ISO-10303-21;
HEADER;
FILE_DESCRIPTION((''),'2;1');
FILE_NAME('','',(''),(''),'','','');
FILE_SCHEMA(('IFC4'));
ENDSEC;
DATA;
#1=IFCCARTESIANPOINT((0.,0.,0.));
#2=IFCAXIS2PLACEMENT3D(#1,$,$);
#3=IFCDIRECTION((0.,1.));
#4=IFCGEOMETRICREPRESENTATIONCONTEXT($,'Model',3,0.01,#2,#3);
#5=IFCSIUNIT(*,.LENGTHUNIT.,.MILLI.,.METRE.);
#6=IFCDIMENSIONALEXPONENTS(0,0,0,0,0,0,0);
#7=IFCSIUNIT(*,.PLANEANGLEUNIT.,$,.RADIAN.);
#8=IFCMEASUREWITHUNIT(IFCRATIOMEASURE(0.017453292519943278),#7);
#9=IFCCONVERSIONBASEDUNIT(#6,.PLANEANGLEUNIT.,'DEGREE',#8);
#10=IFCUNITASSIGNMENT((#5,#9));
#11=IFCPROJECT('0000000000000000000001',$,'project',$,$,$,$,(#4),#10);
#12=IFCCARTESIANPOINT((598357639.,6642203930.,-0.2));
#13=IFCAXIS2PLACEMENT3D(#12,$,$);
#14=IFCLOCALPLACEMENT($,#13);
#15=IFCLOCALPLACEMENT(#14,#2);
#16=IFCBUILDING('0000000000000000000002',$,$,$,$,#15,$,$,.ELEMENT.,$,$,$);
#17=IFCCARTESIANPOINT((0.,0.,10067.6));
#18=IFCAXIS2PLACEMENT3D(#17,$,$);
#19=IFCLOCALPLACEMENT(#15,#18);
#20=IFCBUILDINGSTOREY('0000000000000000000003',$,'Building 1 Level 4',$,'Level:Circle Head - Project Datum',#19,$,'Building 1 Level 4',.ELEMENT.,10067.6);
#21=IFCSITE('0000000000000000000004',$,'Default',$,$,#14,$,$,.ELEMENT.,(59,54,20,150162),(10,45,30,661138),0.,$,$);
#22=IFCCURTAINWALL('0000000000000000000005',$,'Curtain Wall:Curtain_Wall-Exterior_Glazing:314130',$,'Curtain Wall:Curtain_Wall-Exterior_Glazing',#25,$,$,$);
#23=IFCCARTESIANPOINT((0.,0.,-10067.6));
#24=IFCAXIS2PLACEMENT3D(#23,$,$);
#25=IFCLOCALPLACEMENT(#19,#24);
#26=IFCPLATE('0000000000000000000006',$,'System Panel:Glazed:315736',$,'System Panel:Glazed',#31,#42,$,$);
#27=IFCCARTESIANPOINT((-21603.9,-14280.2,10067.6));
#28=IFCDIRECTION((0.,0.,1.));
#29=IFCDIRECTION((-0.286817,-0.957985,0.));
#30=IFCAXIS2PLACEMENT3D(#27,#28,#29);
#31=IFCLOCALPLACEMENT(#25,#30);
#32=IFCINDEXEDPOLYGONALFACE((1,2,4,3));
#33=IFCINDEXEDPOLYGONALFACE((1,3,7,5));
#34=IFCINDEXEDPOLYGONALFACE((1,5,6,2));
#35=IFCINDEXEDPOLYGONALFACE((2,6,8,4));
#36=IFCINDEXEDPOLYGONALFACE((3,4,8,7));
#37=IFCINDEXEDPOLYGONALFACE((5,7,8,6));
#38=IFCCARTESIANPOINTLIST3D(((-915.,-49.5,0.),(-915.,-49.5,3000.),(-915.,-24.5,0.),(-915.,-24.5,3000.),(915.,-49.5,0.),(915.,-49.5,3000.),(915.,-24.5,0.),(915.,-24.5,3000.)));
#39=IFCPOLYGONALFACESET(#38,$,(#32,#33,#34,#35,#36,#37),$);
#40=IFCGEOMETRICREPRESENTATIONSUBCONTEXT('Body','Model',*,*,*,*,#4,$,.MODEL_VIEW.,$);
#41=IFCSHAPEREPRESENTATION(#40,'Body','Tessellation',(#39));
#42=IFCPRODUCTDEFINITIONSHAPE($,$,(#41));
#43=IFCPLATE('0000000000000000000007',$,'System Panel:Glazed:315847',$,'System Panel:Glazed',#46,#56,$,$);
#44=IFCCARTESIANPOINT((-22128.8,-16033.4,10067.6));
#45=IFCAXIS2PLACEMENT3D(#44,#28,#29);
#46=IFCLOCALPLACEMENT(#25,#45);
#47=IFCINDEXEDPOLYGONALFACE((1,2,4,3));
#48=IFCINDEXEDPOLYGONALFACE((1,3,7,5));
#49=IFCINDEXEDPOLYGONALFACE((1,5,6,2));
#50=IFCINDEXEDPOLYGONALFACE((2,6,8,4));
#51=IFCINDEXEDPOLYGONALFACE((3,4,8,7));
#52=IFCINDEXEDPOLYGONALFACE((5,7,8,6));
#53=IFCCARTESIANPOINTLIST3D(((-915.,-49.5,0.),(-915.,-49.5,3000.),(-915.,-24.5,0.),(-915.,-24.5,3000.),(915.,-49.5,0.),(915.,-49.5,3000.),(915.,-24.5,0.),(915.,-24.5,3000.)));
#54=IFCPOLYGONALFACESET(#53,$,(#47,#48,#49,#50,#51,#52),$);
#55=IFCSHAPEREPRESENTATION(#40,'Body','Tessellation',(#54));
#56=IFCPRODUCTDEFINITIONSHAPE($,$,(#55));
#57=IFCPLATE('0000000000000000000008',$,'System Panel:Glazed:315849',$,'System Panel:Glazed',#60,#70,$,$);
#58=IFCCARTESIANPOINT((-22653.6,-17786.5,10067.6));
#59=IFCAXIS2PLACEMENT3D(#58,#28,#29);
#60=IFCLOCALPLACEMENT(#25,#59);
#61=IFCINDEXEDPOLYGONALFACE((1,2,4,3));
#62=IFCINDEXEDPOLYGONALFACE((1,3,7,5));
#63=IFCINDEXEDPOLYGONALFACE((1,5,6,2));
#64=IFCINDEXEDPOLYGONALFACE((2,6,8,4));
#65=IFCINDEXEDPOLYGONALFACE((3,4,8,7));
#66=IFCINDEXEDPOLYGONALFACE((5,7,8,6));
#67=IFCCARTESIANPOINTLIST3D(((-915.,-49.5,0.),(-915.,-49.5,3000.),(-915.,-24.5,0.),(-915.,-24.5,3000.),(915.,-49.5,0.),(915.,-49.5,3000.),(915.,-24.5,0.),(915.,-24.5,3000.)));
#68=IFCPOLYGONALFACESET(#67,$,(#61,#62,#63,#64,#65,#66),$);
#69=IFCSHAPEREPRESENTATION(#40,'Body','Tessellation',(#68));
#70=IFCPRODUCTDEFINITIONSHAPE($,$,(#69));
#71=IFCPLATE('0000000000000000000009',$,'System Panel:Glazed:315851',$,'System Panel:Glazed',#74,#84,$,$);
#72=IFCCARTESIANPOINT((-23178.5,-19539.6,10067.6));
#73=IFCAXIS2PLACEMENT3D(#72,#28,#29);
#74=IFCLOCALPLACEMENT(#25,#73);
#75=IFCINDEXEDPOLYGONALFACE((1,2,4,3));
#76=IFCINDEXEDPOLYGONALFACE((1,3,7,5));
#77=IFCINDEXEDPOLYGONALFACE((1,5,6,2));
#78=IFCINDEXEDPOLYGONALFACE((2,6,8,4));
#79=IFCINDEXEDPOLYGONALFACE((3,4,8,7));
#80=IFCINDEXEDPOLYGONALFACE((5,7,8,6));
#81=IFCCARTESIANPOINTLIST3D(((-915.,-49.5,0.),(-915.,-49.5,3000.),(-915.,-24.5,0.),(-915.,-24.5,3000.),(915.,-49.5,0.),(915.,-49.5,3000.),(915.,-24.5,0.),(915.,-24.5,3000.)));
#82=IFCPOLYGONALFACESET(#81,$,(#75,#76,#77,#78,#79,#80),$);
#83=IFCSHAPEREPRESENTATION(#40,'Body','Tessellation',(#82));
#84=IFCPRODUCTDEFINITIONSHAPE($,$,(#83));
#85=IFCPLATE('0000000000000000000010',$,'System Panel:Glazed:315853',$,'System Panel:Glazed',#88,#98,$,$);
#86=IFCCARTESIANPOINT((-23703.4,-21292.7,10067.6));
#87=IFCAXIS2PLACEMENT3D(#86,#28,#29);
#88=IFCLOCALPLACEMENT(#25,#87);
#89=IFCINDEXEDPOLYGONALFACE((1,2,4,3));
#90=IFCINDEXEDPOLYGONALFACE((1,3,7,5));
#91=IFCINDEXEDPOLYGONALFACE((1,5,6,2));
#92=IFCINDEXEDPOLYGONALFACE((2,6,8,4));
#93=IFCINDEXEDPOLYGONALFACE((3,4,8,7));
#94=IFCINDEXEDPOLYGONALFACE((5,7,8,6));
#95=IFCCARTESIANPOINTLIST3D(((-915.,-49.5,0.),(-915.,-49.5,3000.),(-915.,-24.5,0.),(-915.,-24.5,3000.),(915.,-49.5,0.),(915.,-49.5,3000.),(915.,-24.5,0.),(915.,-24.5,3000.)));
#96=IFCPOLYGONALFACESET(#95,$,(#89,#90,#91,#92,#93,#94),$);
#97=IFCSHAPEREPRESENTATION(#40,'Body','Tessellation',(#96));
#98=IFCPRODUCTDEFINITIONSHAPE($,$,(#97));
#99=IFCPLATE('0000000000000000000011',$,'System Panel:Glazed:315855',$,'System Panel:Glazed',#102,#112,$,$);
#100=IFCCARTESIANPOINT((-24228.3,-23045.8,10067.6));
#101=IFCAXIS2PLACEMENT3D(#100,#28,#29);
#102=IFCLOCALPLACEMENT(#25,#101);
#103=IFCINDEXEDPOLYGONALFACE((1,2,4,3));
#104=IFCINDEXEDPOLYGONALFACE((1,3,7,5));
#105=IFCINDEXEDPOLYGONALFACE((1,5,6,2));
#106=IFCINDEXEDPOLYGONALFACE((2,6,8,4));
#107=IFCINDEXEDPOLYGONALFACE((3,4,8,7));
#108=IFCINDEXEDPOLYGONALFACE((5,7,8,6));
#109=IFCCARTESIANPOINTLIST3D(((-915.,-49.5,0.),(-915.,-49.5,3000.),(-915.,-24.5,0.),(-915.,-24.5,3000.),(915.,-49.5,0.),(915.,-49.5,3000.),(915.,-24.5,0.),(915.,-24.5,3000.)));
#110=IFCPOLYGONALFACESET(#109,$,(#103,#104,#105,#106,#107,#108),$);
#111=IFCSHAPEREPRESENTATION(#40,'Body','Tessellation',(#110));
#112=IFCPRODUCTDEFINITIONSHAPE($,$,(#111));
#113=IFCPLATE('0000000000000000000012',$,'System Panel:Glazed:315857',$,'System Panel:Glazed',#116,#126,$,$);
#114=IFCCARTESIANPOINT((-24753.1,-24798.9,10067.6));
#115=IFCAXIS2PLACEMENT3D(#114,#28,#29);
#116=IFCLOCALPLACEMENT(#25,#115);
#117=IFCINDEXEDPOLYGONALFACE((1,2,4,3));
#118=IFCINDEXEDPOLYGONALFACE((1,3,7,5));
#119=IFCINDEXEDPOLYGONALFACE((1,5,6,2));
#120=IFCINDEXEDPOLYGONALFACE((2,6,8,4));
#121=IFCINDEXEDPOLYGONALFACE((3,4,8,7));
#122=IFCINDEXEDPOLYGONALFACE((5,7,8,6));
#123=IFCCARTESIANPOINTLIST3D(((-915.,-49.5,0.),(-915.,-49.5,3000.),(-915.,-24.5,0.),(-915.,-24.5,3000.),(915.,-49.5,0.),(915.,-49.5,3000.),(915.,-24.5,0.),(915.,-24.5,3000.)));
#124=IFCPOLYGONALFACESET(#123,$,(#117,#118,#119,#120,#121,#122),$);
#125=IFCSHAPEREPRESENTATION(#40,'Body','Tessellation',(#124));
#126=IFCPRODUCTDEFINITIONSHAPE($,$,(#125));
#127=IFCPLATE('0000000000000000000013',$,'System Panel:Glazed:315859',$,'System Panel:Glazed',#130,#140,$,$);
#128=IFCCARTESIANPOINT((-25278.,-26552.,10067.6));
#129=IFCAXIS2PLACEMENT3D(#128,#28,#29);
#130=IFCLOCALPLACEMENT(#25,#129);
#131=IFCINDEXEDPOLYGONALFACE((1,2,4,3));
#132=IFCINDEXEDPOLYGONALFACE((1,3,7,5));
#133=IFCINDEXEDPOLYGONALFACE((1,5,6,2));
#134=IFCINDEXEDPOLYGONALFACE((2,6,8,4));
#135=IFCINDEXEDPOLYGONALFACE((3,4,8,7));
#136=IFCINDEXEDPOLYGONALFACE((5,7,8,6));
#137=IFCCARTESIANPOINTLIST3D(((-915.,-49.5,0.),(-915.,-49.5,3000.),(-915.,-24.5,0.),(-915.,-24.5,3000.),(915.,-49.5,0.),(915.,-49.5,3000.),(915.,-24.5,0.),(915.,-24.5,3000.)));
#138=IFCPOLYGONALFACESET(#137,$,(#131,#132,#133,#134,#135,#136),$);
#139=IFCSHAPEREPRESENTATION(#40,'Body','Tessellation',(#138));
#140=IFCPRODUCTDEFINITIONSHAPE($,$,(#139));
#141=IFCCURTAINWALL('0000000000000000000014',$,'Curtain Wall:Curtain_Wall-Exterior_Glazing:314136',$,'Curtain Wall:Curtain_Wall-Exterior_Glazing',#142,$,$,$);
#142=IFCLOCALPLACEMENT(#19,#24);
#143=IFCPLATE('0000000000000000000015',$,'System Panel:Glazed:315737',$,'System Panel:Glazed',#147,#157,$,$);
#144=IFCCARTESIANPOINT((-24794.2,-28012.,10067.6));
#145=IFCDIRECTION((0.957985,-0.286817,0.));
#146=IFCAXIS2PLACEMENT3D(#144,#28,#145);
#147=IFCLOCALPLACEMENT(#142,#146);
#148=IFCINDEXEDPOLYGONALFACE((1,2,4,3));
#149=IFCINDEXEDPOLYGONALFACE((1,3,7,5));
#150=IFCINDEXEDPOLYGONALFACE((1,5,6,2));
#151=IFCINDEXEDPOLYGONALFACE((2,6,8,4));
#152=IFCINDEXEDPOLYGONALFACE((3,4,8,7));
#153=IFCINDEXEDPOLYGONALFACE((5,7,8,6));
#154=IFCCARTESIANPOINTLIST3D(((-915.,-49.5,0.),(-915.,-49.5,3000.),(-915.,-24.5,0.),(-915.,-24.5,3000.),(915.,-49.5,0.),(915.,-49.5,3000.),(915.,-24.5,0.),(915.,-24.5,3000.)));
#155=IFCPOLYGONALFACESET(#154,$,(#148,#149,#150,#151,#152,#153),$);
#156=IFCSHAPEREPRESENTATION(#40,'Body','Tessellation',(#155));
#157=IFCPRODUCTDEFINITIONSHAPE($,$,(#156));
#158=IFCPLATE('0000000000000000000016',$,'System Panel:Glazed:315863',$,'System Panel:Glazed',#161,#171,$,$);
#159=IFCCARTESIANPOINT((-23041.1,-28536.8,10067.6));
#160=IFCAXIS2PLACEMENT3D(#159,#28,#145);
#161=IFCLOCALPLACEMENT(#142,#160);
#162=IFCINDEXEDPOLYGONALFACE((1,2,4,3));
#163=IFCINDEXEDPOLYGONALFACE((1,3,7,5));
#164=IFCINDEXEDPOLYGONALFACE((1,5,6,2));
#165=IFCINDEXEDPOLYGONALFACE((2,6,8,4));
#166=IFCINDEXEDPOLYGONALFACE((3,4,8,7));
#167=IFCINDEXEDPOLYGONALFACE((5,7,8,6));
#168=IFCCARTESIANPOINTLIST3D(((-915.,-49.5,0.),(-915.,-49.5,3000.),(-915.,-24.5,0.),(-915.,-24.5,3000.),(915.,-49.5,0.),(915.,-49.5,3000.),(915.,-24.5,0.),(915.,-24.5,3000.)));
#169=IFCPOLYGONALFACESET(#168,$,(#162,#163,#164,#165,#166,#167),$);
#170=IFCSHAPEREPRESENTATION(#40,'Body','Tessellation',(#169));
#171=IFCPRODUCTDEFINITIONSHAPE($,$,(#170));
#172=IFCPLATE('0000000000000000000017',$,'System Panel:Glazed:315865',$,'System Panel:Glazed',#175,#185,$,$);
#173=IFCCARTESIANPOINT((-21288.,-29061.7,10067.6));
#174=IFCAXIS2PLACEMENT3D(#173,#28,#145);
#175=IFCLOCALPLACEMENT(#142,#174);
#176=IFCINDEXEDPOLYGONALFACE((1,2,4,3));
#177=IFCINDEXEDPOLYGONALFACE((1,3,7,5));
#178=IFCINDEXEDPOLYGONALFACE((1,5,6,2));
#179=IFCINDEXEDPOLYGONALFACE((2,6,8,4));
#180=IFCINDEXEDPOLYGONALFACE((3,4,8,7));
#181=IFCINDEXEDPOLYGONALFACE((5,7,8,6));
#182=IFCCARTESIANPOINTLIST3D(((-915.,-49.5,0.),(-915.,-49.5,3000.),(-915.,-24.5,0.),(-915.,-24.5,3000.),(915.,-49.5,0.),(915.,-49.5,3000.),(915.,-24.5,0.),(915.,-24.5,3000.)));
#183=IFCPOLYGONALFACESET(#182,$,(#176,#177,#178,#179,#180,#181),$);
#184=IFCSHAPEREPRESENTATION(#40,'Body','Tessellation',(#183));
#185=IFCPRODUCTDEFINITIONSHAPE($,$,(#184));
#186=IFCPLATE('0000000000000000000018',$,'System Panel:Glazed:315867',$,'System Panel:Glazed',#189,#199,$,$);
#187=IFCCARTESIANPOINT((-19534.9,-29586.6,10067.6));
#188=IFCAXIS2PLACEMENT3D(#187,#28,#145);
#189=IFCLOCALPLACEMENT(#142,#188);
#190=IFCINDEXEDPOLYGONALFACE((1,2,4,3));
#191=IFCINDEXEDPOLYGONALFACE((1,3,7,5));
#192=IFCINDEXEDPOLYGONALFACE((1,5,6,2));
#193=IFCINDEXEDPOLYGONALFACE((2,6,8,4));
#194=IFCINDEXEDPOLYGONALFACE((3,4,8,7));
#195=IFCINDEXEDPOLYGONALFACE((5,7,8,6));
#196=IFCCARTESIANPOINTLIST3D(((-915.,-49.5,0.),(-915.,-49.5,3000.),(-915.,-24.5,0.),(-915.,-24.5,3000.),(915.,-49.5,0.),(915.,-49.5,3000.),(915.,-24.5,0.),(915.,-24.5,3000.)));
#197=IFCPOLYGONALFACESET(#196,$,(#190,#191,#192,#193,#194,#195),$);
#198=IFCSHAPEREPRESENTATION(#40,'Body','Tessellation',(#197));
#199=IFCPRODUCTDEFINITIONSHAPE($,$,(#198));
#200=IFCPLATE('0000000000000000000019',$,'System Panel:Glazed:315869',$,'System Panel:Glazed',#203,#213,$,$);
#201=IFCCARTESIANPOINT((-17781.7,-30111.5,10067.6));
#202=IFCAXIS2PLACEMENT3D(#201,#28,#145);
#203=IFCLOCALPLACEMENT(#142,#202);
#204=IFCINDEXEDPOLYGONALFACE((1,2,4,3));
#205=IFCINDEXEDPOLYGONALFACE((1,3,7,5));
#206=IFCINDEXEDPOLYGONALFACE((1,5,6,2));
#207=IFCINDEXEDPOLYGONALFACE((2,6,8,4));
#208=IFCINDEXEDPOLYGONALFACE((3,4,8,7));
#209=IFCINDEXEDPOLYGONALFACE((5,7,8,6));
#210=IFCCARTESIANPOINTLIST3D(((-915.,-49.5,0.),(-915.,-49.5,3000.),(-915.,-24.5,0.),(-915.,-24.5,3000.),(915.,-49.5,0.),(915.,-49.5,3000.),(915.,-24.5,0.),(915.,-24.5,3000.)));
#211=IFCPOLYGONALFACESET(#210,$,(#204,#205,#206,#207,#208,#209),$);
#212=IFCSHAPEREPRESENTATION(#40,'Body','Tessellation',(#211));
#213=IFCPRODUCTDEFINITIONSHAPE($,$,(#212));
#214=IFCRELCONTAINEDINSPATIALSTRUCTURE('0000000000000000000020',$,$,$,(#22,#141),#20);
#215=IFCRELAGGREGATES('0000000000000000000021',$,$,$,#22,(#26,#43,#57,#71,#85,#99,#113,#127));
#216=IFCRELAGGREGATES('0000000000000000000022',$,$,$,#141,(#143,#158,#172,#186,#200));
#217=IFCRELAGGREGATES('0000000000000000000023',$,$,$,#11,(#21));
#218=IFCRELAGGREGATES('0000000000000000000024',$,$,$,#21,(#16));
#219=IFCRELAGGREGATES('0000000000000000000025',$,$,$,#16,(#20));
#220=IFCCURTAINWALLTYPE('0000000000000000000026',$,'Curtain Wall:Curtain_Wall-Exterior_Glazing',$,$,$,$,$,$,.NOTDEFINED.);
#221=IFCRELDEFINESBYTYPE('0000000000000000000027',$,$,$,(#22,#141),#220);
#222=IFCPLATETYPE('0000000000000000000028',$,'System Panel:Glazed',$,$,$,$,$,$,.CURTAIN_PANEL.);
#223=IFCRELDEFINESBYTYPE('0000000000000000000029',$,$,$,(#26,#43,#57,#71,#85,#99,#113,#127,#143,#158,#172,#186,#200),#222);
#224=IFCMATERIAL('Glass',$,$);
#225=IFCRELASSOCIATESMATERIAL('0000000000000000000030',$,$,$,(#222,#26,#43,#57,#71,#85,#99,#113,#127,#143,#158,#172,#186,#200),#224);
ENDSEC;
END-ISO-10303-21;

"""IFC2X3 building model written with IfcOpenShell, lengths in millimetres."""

from ifc_helpers import new_model, entity, si_unit, converted_unit, direction, frame, frame_2d, origin, place, context, subcontext, project, spatial, rectangle, extrude, source, transform, mapped, material, type_object, type_shapes, element, aggregate, save


model = new_model("IFC2X3")

# Units and contexts
model_context = context("Model", 3, precision=0.01, world=origin(), true_north=direction((0.0, 1.0)))
body_context = subcontext(model_context, "Body", "Model", "MODEL_VIEW")
ifc_project = project(units=[si_unit("LENGTHUNIT", "METRE", prefix="MILLI"), converted_unit("PLANEANGLEUNIT", "DEGREE", entity("IfcRatioMeasure", 0.017453292519943278), si_unit("PLANEANGLEUNIT", "RADIAN"), dimensions=[0, 0, 0, 0, 0, 0, 0])], contexts=[model_context])

# Site, building, storey
site_placement = place(None, frame((598357639.0, 6642203930.0, -0.2)))
site = spatial("IfcSite", under=ifc_project, at=site_placement, Name="Default", CompositionType="ELEMENT", RefLatitude=(59, 54, 20, 150162), RefLongitude=(10, 45, 30, 661138), RefElevation=0.0)
building_placement = place(site_placement, origin())
building = spatial("IfcBuilding", under=site, at=building_placement, CompositionType="ELEMENT")
storey_placement = place(building_placement, frame((0.0, 0.0, 10067.6)))
storey = spatial("IfcBuildingStorey", under=building, at=storey_placement, Name="Building 1 Level 4", ObjectType="Level:Circle Head - Project Datum", LongName="Building 1 Level 4", CompositionType="ELEMENT", Elevation=10067.6)

# Curtain walls, plates
curtain_wall_type = type_object("IfcCurtainWallType", Name="Curtain Wall:Curtain_Wall-Exterior_Glazing", PredefinedType="NOTDEFINED")
curtain_wall_1_placement = place(storey_placement, frame((0.0, 0.0, -10067.6)))
curtain_wall_1 = element("IfcCurtainWall", 1, at=curtain_wall_1_placement, inside=storey, type_object=curtain_wall_type, Name="Curtain Wall:Curtain_Wall-Exterior_Glazing:314130", ObjectType="Curtain Wall:Curtain_Wall-Exterior_Glazing")
ifc_material_1 = material(Name="Glass")
plate_type_1 = type_object("IfcPlateType", Name="System Panel:Glazed", PredefinedType="CURTAIN_PANEL", material=ifc_material_1)
shared_shape_1 = source(origin(), body_context, "Body", "SweptSolid", [
    extrude(rectangle(XDim=25.0, YDim=1830.0, at=frame_2d((0.0, 0.0), x_axis=(1.0, 0.0))), frame((0.0, -37.0, 0.0), z_axis=(0.0, 0.0, 1.0), x_axis=(0.0, 1.0, 0.0)), (0.0, 0.0, 1.0), 3000.0),
])
type_shapes(plate_type_1, [shared_shape_1])
plate_1_placement = place(curtain_wall_1_placement, frame((-21603.9, -14280.2, 10067.6), z_axis=(0.0, 0.0, 1.0), x_axis=(-0.286817, -0.957985, 0.0)))
plate_1 = element("IfcPlate", 2, at=plate_1_placement, type_object=plate_type_1, material=ifc_material_1, Name="System Panel:Glazed:315736", ObjectType="System Panel:Glazed", context=body_context, shape_type="MappedRepresentation", body=[
    mapped(shared_shape_1, transform((0.0, 0.0, 0.0), scale=1.0)),
])
plate_2_placement = place(curtain_wall_1_placement, frame((-22128.8, -16033.4, 10067.6), z_axis=(0.0, 0.0, 1.0), x_axis=(-0.286817, -0.957985, 0.0)))
plate_2 = element("IfcPlate", 3, at=plate_2_placement, type_object=plate_type_1, material=ifc_material_1, Name="System Panel:Glazed:315847", ObjectType="System Panel:Glazed", context=body_context, shape_type="MappedRepresentation", body=[
    mapped(shared_shape_1, transform((0.0, 0.0, 0.0), scale=1.0)),
])
plate_3_placement = place(curtain_wall_1_placement, frame((-22653.6, -17786.5, 10067.6), z_axis=(0.0, 0.0, 1.0), x_axis=(-0.286817, -0.957985, 0.0)))
plate_3 = element("IfcPlate", 4, at=plate_3_placement, type_object=plate_type_1, material=ifc_material_1, Name="System Panel:Glazed:315849", ObjectType="System Panel:Glazed", context=body_context, shape_type="MappedRepresentation", body=[
    mapped(shared_shape_1, transform((0.0, 0.0, 0.0), scale=1.0)),
])
plate_4_placement = place(curtain_wall_1_placement, frame((-23178.5, -19539.6, 10067.6), z_axis=(0.0, 0.0, 1.0), x_axis=(-0.286817, -0.957985, 0.0)))
plate_4 = element("IfcPlate", 5, at=plate_4_placement, type_object=plate_type_1, material=ifc_material_1, Name="System Panel:Glazed:315851", ObjectType="System Panel:Glazed", context=body_context, shape_type="MappedRepresentation", body=[
    mapped(shared_shape_1, transform((0.0, 0.0, 0.0), scale=1.0)),
])
plate_5_placement = place(curtain_wall_1_placement, frame((-23703.4, -21292.7, 10067.6), z_axis=(0.0, 0.0, 1.0), x_axis=(-0.286817, -0.957985, 0.0)))
plate_5 = element("IfcPlate", 6, at=plate_5_placement, type_object=plate_type_1, material=ifc_material_1, Name="System Panel:Glazed:315853", ObjectType="System Panel:Glazed", context=body_context, shape_type="MappedRepresentation", body=[
    mapped(shared_shape_1, transform((0.0, 0.0, 0.0), scale=1.0)),
])
plate_6_placement = place(curtain_wall_1_placement, frame((-24228.3, -23045.8, 10067.6), z_axis=(0.0, 0.0, 1.0), x_axis=(-0.286817, -0.957985, 0.0)))
plate_6 = element("IfcPlate", 7, at=plate_6_placement, type_object=plate_type_1, material=ifc_material_1, Name="System Panel:Glazed:315855", ObjectType="System Panel:Glazed", context=body_context, shape_type="MappedRepresentation", body=[
    mapped(shared_shape_1, transform((0.0, 0.0, 0.0), scale=1.0)),
])
plate_7_placement = place(curtain_wall_1_placement, frame((-24753.1, -24798.9, 10067.6), z_axis=(0.0, 0.0, 1.0), x_axis=(-0.286817, -0.957985, 0.0)))
plate_7 = element("IfcPlate", 8, at=plate_7_placement, type_object=plate_type_1, material=ifc_material_1, Name="System Panel:Glazed:315857", ObjectType="System Panel:Glazed", context=body_context, shape_type="MappedRepresentation", body=[
    mapped(shared_shape_1, transform((0.0, 0.0, 0.0), scale=1.0)),
])
plate_8_placement = place(curtain_wall_1_placement, frame((-25278.0, -26552.0, 10067.6), z_axis=(0.0, 0.0, 1.0), x_axis=(-0.286817, -0.957985, 0.0)))
plate_8 = element("IfcPlate", 9, at=plate_8_placement, type_object=plate_type_1, material=ifc_material_1, Name="System Panel:Glazed:315859", ObjectType="System Panel:Glazed", context=body_context, shape_type="MappedRepresentation", body=[
    mapped(shared_shape_1, transform((0.0, 0.0, 0.0), scale=1.0)),
])
curtain_wall_2_placement = place(storey_placement, frame((0.0, 0.0, -10067.6)))
curtain_wall_2 = element("IfcCurtainWall", 10, at=curtain_wall_2_placement, inside=storey, type_object=curtain_wall_type, Name="Curtain Wall:Curtain_Wall-Exterior_Glazing:314136", ObjectType="Curtain Wall:Curtain_Wall-Exterior_Glazing")
plate_9_placement = place(curtain_wall_2_placement, frame((-24794.2, -28012.0, 10067.6), z_axis=(0.0, 0.0, 1.0), x_axis=(0.957985, -0.286817, 0.0)))
plate_9 = element("IfcPlate", 11, at=plate_9_placement, type_object=plate_type_1, material=ifc_material_1, Name="System Panel:Glazed:315737", ObjectType="System Panel:Glazed", context=body_context, shape_type="MappedRepresentation", body=[
    mapped(shared_shape_1, transform((0.0, 0.0, 0.0), scale=1.0)),
])
plate_10_placement = place(curtain_wall_2_placement, frame((-23041.1, -28536.8, 10067.6), z_axis=(0.0, 0.0, 1.0), x_axis=(0.957985, -0.286817, 0.0)))
plate_10 = element("IfcPlate", 12, at=plate_10_placement, type_object=plate_type_1, material=ifc_material_1, Name="System Panel:Glazed:315863", ObjectType="System Panel:Glazed", context=body_context, shape_type="MappedRepresentation", body=[
    mapped(shared_shape_1, transform((0.0, 0.0, 0.0), scale=1.0)),
])
plate_11_placement = place(curtain_wall_2_placement, frame((-21288.0, -29061.7, 10067.6), z_axis=(0.0, 0.0, 1.0), x_axis=(0.957985, -0.286817, 0.0)))
plate_11 = element("IfcPlate", 13, at=plate_11_placement, type_object=plate_type_1, material=ifc_material_1, Name="System Panel:Glazed:315865", ObjectType="System Panel:Glazed", context=body_context, shape_type="MappedRepresentation", body=[
    mapped(shared_shape_1, transform((0.0, 0.0, 0.0), scale=1.0)),
])
plate_12_placement = place(curtain_wall_2_placement, frame((-19534.9, -29586.6, 10067.6), z_axis=(0.0, 0.0, 1.0), x_axis=(0.957985, -0.286817, 0.0)))
plate_12 = element("IfcPlate", 14, at=plate_12_placement, type_object=plate_type_1, material=ifc_material_1, Name="System Panel:Glazed:315867", ObjectType="System Panel:Glazed", context=body_context, shape_type="MappedRepresentation", body=[
    mapped(shared_shape_1, transform((0.0, 0.0, 0.0), scale=1.0)),
])
plate_13_placement = place(curtain_wall_2_placement, frame((-17781.7, -30111.5, 10067.6), z_axis=(0.0, 0.0, 1.0), x_axis=(0.957985, -0.286817, 0.0)))
plate_13 = element("IfcPlate", 15, at=plate_13_placement, type_object=plate_type_1, material=ifc_material_1, Name="System Panel:Glazed:315869", ObjectType="System Panel:Glazed", context=body_context, shape_type="MappedRepresentation", body=[
    mapped(shared_shape_1, transform((0.0, 0.0, 0.0), scale=1.0)),
])

aggregate(curtain_wall_1, [plate_1, plate_2, plate_3, plate_4, plate_5, plate_6, plate_7, plate_8])
aggregate(curtain_wall_2, [plate_9, plate_10, plate_11, plate_12, plate_13])

save(model, "model.ifc")
